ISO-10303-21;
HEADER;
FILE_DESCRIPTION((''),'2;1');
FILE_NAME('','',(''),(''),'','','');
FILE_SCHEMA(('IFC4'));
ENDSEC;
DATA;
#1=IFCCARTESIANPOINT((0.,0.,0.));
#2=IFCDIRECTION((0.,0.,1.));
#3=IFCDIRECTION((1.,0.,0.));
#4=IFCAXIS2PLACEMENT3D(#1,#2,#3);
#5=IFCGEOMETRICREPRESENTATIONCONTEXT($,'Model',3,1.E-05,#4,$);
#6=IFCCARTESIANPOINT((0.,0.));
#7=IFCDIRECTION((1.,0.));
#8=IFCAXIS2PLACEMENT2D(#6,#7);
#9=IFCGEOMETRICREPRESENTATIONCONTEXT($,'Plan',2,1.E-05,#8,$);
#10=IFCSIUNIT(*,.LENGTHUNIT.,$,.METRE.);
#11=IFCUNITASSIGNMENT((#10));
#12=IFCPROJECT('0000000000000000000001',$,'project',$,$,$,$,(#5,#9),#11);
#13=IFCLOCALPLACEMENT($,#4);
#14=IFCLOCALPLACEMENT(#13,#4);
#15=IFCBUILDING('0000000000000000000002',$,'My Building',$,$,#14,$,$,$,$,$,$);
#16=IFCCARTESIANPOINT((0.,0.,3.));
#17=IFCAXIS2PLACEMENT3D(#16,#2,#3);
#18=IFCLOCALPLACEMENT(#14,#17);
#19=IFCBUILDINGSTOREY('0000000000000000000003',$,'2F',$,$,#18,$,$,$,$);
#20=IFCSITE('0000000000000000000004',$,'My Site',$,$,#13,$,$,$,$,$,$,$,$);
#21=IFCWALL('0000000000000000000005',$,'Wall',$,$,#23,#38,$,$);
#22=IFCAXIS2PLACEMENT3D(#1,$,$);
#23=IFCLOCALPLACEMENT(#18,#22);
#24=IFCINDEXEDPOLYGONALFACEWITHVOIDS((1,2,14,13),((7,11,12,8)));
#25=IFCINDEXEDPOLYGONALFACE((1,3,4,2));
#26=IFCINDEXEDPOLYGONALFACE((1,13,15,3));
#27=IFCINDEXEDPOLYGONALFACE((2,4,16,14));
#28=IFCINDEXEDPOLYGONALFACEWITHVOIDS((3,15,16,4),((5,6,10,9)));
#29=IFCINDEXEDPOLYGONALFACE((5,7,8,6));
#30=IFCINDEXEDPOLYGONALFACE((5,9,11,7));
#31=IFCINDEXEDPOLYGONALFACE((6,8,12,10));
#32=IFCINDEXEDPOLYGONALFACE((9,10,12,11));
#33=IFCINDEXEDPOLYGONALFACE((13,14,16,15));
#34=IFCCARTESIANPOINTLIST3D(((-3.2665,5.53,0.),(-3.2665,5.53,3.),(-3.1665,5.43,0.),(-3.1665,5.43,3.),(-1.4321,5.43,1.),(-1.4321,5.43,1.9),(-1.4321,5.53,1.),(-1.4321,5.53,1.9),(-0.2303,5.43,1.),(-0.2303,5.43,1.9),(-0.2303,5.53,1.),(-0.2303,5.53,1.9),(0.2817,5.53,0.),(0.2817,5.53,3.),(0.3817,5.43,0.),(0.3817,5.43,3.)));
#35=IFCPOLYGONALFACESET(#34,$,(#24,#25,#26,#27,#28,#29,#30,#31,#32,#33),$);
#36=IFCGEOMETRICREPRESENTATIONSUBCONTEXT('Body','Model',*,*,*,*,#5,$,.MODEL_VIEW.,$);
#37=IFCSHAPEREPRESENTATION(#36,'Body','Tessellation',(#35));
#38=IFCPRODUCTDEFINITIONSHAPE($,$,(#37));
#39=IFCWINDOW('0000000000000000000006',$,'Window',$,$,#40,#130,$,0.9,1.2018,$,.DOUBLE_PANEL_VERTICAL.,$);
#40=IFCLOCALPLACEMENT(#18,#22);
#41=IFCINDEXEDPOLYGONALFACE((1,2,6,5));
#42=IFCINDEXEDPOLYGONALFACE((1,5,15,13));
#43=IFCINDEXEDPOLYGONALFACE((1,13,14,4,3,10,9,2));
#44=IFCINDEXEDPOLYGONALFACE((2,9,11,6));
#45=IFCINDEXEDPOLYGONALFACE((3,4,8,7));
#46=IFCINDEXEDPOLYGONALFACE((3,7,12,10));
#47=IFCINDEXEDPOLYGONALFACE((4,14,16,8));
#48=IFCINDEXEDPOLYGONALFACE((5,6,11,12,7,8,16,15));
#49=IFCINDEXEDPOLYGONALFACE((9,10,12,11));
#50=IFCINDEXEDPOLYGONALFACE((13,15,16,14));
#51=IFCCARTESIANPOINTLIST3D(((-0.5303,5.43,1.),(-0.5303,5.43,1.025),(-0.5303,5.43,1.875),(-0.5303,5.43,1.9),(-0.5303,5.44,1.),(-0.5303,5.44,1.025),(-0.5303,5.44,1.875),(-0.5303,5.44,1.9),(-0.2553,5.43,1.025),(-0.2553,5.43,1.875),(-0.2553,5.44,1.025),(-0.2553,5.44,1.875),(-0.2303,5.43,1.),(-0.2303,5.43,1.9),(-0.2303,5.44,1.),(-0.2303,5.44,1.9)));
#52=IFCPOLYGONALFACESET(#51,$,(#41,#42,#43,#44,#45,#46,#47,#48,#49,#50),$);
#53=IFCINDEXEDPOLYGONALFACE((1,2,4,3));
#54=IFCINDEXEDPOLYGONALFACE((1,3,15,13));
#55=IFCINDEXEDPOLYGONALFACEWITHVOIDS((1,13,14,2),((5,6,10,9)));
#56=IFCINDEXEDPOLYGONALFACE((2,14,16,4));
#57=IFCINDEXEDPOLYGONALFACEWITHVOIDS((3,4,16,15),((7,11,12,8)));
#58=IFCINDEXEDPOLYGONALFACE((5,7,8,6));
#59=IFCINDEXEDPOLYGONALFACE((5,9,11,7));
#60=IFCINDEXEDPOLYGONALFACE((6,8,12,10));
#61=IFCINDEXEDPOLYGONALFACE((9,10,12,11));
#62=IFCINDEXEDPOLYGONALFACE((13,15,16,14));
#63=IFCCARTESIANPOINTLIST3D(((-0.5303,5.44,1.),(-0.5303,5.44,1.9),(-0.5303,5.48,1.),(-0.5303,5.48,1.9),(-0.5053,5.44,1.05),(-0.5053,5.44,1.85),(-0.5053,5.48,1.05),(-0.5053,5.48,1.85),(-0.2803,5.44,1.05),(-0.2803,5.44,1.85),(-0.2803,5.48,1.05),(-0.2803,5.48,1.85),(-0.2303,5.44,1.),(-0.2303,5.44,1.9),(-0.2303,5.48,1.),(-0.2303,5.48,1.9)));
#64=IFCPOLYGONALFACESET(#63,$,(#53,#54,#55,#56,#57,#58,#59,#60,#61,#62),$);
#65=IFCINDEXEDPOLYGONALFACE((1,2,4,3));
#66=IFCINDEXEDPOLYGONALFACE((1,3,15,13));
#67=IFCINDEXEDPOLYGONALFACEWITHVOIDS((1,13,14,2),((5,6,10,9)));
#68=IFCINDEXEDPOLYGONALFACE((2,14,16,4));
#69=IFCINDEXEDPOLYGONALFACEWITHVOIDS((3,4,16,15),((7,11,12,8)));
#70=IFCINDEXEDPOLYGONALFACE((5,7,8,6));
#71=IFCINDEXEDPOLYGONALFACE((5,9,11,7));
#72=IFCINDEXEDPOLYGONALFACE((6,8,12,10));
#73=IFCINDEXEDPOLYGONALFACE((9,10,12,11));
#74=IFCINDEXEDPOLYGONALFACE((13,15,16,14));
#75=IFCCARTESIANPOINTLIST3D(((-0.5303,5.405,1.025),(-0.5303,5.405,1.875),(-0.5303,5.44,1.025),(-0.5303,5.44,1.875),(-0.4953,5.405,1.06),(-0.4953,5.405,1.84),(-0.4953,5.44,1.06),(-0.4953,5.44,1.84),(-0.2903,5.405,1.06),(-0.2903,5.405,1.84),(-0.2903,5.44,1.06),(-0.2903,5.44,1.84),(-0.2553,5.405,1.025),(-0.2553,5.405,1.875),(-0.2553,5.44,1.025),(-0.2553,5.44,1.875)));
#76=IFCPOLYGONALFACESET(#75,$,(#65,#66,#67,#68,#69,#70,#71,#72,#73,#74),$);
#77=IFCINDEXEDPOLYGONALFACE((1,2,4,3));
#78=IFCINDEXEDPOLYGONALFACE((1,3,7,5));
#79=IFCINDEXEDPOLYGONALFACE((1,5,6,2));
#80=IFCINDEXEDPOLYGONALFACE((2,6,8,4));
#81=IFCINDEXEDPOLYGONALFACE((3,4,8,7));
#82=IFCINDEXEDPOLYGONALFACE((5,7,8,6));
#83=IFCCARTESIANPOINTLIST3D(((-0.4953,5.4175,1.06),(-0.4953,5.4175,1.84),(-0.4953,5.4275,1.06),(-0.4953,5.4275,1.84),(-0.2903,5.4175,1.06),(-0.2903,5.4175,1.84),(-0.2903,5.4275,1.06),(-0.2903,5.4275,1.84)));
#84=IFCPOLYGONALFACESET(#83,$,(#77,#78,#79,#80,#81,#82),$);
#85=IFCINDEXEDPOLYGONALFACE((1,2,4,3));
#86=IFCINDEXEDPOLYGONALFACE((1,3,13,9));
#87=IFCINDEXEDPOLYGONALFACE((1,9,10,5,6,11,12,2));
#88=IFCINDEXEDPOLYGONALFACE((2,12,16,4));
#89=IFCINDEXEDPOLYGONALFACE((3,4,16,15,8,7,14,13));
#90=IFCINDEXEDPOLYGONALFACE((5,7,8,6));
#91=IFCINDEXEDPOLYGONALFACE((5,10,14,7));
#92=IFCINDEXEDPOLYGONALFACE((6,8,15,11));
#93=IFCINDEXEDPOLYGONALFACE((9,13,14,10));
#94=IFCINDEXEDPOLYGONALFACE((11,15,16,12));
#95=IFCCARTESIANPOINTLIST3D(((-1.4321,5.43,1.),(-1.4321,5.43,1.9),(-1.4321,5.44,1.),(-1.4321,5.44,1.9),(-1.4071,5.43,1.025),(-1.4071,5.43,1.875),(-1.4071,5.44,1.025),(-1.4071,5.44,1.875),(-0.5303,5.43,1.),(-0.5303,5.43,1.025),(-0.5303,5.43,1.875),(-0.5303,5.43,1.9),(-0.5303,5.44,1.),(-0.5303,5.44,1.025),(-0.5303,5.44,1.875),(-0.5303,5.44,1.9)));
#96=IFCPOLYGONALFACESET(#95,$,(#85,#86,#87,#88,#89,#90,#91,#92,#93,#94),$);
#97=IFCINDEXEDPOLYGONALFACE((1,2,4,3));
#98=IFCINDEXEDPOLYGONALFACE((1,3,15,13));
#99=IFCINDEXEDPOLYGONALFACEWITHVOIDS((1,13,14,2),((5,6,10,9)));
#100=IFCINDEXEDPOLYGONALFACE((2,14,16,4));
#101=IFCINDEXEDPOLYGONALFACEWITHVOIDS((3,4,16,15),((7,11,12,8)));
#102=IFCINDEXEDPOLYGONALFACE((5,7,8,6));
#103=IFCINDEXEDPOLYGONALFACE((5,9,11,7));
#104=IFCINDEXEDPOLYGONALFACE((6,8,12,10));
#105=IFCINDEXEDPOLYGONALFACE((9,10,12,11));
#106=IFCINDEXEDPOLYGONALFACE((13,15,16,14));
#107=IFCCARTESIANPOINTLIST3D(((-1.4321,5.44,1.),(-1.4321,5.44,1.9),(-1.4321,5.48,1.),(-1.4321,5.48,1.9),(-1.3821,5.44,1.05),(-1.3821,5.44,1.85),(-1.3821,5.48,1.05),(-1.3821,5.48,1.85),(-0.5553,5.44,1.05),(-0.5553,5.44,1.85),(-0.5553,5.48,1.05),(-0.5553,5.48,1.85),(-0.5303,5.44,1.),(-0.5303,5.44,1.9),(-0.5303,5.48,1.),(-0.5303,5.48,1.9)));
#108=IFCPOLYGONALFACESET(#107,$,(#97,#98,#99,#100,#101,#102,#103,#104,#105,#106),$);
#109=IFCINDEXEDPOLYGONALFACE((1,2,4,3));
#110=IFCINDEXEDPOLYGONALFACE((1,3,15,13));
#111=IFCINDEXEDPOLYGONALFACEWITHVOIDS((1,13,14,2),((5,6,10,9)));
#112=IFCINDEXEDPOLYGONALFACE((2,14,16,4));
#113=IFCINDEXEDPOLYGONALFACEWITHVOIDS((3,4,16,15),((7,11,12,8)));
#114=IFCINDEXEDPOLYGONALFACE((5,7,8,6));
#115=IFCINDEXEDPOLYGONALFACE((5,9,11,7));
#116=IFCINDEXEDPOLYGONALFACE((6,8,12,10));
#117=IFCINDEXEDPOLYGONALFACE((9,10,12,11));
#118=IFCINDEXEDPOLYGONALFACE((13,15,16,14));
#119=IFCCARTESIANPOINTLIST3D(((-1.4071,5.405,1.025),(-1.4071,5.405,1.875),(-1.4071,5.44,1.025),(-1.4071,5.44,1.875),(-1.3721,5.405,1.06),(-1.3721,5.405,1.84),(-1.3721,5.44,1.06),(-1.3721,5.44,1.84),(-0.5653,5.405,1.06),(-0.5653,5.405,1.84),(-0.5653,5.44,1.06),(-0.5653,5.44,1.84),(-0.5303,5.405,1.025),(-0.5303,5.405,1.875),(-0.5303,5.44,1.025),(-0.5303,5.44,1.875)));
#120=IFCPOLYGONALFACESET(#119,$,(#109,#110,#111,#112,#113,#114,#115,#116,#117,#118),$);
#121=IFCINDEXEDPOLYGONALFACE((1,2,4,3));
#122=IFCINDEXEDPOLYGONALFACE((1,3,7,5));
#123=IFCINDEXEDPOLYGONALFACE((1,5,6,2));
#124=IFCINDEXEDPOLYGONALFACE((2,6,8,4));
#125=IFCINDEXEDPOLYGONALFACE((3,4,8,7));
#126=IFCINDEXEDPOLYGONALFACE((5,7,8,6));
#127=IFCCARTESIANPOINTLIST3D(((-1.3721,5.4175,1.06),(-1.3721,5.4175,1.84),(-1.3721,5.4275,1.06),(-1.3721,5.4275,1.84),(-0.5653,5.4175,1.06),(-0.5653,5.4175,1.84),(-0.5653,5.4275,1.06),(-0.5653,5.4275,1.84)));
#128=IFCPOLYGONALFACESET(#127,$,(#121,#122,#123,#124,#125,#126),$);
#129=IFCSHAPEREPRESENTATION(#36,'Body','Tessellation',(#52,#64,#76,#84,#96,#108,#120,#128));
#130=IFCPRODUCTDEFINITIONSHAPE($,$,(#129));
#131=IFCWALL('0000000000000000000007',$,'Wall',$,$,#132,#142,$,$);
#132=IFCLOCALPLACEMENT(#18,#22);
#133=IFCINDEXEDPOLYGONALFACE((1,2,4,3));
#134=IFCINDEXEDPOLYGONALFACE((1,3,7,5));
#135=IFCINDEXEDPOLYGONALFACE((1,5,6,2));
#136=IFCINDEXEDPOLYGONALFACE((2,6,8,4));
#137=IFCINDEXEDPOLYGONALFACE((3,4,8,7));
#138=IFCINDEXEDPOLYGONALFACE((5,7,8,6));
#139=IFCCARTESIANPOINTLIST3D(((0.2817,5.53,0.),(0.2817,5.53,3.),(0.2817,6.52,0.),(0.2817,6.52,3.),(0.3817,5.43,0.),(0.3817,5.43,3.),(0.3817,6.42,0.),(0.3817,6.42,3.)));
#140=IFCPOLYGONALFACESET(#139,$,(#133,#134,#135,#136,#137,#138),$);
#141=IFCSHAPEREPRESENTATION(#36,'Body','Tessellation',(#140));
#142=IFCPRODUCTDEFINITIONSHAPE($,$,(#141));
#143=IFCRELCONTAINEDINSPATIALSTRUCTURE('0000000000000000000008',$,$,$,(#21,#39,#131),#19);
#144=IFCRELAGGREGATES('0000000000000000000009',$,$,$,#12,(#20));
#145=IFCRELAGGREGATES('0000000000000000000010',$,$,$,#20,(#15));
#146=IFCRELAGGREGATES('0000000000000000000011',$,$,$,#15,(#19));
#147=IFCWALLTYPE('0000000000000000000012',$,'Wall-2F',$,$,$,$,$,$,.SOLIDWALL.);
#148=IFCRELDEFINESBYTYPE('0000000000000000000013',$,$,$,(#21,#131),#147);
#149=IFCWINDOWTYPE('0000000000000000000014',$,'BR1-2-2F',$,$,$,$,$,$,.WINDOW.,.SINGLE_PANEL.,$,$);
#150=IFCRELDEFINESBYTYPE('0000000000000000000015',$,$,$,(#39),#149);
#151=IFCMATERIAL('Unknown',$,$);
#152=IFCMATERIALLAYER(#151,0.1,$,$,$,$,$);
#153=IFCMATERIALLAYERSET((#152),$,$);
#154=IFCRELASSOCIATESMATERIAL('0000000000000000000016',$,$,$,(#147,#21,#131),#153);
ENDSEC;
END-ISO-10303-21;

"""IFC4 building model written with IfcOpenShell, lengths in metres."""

from ifc_helpers import new_model, entity, si_unit, frame, origin_with_axes, origin_2d_with_axis, place, context, subcontext, project, spatial, line, indexed_curve, outline, extrude, shape, source, transform, mapped, material, layer, layer_set, layer_usage, type_object, type_shapes, element, fill, save


model = new_model("IFC4")

# Units and contexts
model_context = context("Model", 3, precision=1e-05, world=origin_with_axes())
plan_context = context("Plan", 2, precision=1e-05, world=origin_2d_with_axis())
body_context_1 = subcontext(model_context, "Body", "Model", "MODEL_VIEW")
body_context_2 = subcontext(plan_context, "Body", "Plan", "PLAN_VIEW")
ifc_project = project(units=[si_unit("LENGTHUNIT", "METRE")], contexts=[model_context, plan_context])

# Site, building, storey
site_placement = place(None, origin_with_axes())
site = spatial("IfcSite", under=ifc_project, at=site_placement, Name="My Site")
building_placement = place(site_placement, origin_with_axes())
building = spatial("IfcBuilding", under=site, at=building_placement, Name="My Building")
storey_placement = place(building_placement, frame((0.0, 0.0, 3.0), z_axis=(0.0, 0.0, 1.0), x_axis=(1.0, 0.0, 0.0)))
storey = spatial("IfcBuildingStorey", under=building, at=storey_placement, Name="2F")

# Shared definitions
ifc_material = material(Name="Unknown")

# Shared definitions
ifc_layer_1 = layer(ifc_material, 0.1)
ifc_layer_set_1 = layer_set([ifc_layer_1])
wall_type_1 = type_object("IfcWallType", Name="Wall-2F", PredefinedType="SOLIDWALL", material=ifc_layer_set_1)

# Wall, opening, window
ifc_layer_usage_1 = layer_usage(ifc_layer_set_1, "AXIS2", "POSITIVE", 0.0)
wall_1_placement = place(storey_placement, frame((0.2817, 5.53, 0.0), z_axis=(0.0, 0.0, 1.0), x_axis=(-1.0, 0.0, 0.0)))
wall_1 = element("IfcWall", 1, at=wall_1_placement, inside=storey, type_object=wall_type_1, material=ifc_layer_usage_1, Name="Wall", context=body_context_1, shape_type="SweptSolid", body=[
    extrude(outline(indexed_curve([(0.0, 0.0), (-0.1, 0.1), (3.4482, 0.1), (3.5482, 0.0)], segments=[line(1, 2, 3, 4, 1)])), origin_with_axes(), (0.0, 0.0, 1.0), 3.0),
])
shared_shape_1 = source(origin_with_axes(), body_context_1, "Body", "SweptSolid", [
    extrude(outline(indexed_curve([(0.0, 0.0), (1.2018, 0.0), (1.2018, 0.9), (0.0, 0.9)], segments=[line(1, 2, 3, 4, 1)])), frame((0.0, -0.6, 0.0), z_axis=(0.0, -1.0, 0.0), x_axis=(1.0, 0.0, 0.0)), (0.0, 0.0, -1.0), 1.2),
])
opening_1_placement = place(wall_1_placement, frame((0.512, 0.0, 1.0), z_axis=(0.0, 0.0, 1.0), x_axis=(1.0, 0.0, 0.0)))
opening_1 = element("IfcOpeningElement", 2, at=opening_1_placement, cuts=wall_1, PredefinedType="OPENING", context=body_context_1, shape_type="MappedRepresentation", body=[
    mapped(shared_shape_1, transform((0.0, 0.0, 0.0), x_axis=(1.0, 0.0, 0.0), y_axis=(0.0, 1.0, 0.0), z_axis=(0.0, 0.0, 1.0), scale=1.0)),
])
window_type_1 = type_object("IfcWindowType", Name="BR1-2-2F", PartitioningType="SINGLE_PANEL", PredefinedType="WINDOW")
shared_shape_2 = source(origin_with_axes(), body_context_1, "Body", "SweptSolid", [
    extrude(outline(indexed_curve([(0.3, 0.0), (0.0, 0.0), (0.0, 0.9), (0.3, 0.9), (0.3, 0.875), (0.025, 0.875), (0.025, 0.025), (0.3, 0.025)], segments=[line(1, 2, 3, 4, 5, 6, 7, 8, 1)])), frame((0.0, 0.09, 0.0), z_axis=(0.0, -1.0, 0.0), x_axis=(1.0, 0.0, 0.0)), (0.0, 0.0, -1.0), 0.01),
    extrude(outline(indexed_curve([(0.0, 0.0), (0.3, 0.0), (0.3, 0.9), (0.0, 0.9)], segments=[line(1, 2, 3, 4, 1)]), holes=[indexed_curve([(0.05, 0.05), (0.275, 0.05), (0.275, 0.85), (0.05, 0.85)], segments=[line(1, 2, 3, 4, 1)])]), frame((0.0, 0.05, 0.0), z_axis=(0.0, -1.0, 0.0), x_axis=(1.0, 0.0, 0.0)), (0.0, 0.0, -1.0), 0.04),
    extrude(outline(indexed_curve([(0.0, 0.0), (0.275, 0.0), (0.275, 0.85), (0.0, 0.85)], segments=[line(1, 2, 3, 4, 1)]), holes=[indexed_curve([(0.035, 0.035), (0.24, 0.035), (0.24, 0.815), (0.035, 0.815)], segments=[line(1, 2, 3, 4, 1)])]), frame((0.025, 0.09, 0.025), z_axis=(0.0, -1.0, 0.0), x_axis=(1.0, 0.0, 0.0)), (0.0, 0.0, -1.0), 0.035),
    extrude(outline(indexed_curve([(0.035, 0.035), (0.24, 0.035), (0.24, 0.815), (0.035, 0.815)], segments=[line(1, 2, 3, 4, 1)])), frame((0.025, 0.1025, 0.025), z_axis=(0.0, -1.0, 0.0), x_axis=(1.0, 0.0, 0.0)), (0.0, 0.0, -1.0), 0.01),
    extrude(outline(indexed_curve([(0.0, 0.9), (0.9018, 0.9), (0.9018, 0.0), (0.0, 0.0), (0.0, 0.025), (0.8768, 0.025), (0.8768, 0.875), (0.0, 0.875)], segments=[line(1, 2, 3, 4, 5, 6, 7, 8, 1)])), frame((0.3, 0.09, 0.0), z_axis=(0.0, -1.0, 0.0), x_axis=(1.0, 0.0, 0.0)), (0.0, 0.0, -1.0), 0.01),
    extrude(outline(indexed_curve([(0.0, 0.0), (0.9018, 0.0), (0.9018, 0.9), (0.0, 0.9)], segments=[line(1, 2, 3, 4, 1)]), holes=[indexed_curve([(0.025, 0.05), (0.8518, 0.05), (0.8518, 0.85), (0.025, 0.85)], segments=[line(1, 2, 3, 4, 1)])]), frame((0.3, 0.05, 0.0), z_axis=(0.0, -1.0, 0.0), x_axis=(1.0, 0.0, 0.0)), (0.0, 0.0, -1.0), 0.04),
    extrude(outline(indexed_curve([(0.0, 0.0), (0.8768, 0.0), (0.8768, 0.85), (0.0, 0.85)], segments=[line(1, 2, 3, 4, 1)]), holes=[indexed_curve([(0.035, 0.035), (0.8418, 0.035), (0.8418, 0.815), (0.035, 0.815)], segments=[line(1, 2, 3, 4, 1)])]), frame((0.3, 0.09, 0.025), z_axis=(0.0, -1.0, 0.0), x_axis=(1.0, 0.0, 0.0)), (0.0, 0.0, -1.0), 0.035),
    extrude(outline(indexed_curve([(0.035, 0.035), (0.8418, 0.035), (0.8418, 0.815), (0.035, 0.815)], segments=[line(1, 2, 3, 4, 1)])), frame((0.3, 0.1025, 0.025), z_axis=(0.0, -1.0, 0.0), x_axis=(1.0, 0.0, 0.0)), (0.0, 0.0, -1.0), 0.01),
])
shared_shape_3 = source(origin_with_axes(), body_context_2, "Body", "Curve2D", [
    entity("IfcIndexedPolyCurve", entity("IfcCartesianPointList2D", [[0.05, 0.05], [0.275, 0.05]])),
    entity("IfcIndexedPolyCurve", entity("IfcCartesianPointList2D", [[0.0, 0.1], [0.025, 0.1], [0.025, 0.09], [0.05, 0.09], [0.05, 0.05], [0.0, 0.05]]), [entity("IfcLineIndex", [1, 2, 3, 4, 5, 6, 1])]),
    entity("IfcIndexedPolyCurve", entity("IfcCartesianPointList2D", [[0.3, 0.1], [0.3, 0.1], [0.3, 0.09], [0.275, 0.09], [0.275, 0.05], [0.3, 0.05]])),
    entity("IfcIndexedPolyCurve", entity("IfcCartesianPointList2D", [[0.025, 0.09], [0.06, 0.09], [0.06, 0.125], [0.025, 0.125]]), [entity("IfcLineIndex", [1, 2, 3, 4, 1])]),
    entity("IfcIndexedPolyCurve", entity("IfcCartesianPointList2D", [[0.3, 0.09], [0.265, 0.09], [0.265, 0.125], [0.3, 0.125]]), [entity("IfcLineIndex", [1, 2, 3, 4, 1])]),
    entity("IfcIndexedPolyCurve", entity("IfcCartesianPointList2D", [[0.06, 0.09], [0.265, 0.09]])),
    entity("IfcIndexedPolyCurve", entity("IfcCartesianPointList2D", [[0.06, 0.125], [0.265, 0.125]])),
    entity("IfcIndexedPolyCurve", entity("IfcCartesianPointList2D", [[0.06, 0.1075], [0.265, 0.1075]])),
    entity("IfcIndexedPolyCurve", entity("IfcCartesianPointList2D", [[0.325, 0.05], [1.1518, 0.05]])),
    entity("IfcIndexedPolyCurve", entity("IfcCartesianPointList2D", [[0.3, 0.1], [0.3, 0.1], [0.3, 0.09], [0.325, 0.09], [0.325, 0.05], [0.3, 0.05]])),
    entity("IfcIndexedPolyCurve", entity("IfcCartesianPointList2D", [[1.2018, 0.1], [1.1768, 0.1], [1.1768, 0.09], [1.1518, 0.09], [1.1518, 0.05], [1.2018, 0.05]]), [entity("IfcLineIndex", [1, 2, 3, 4, 5, 6, 1])]),
    entity("IfcIndexedPolyCurve", entity("IfcCartesianPointList2D", [[0.3, 0.09], [0.335, 0.09], [0.335, 0.125], [0.3, 0.125]]), [entity("IfcLineIndex", [1, 2, 3, 4, 1])]),
    entity("IfcIndexedPolyCurve", entity("IfcCartesianPointList2D", [[1.1768, 0.09], [1.1418, 0.09], [1.1418, 0.125], [1.1768, 0.125]]), [entity("IfcLineIndex", [1, 2, 3, 4, 1])]),
    entity("IfcIndexedPolyCurve", entity("IfcCartesianPointList2D", [[0.335, 0.09], [1.1418, 0.09]])),
    entity("IfcIndexedPolyCurve", entity("IfcCartesianPointList2D", [[0.335, 0.125], [1.1418, 0.125]])),
    entity("IfcIndexedPolyCurve", entity("IfcCartesianPointList2D", [[0.335, 0.1075], [1.1418, 0.1075]])),
])
type_shapes(window_type_1, [shared_shape_2, shared_shape_3])
window_1_placement = place(opening_1_placement, origin_with_axes())
window_1 = element("IfcWindow", 3, at=window_1_placement, inside=storey, type_object=window_type_1, Name="Window", OverallHeight=0.9, OverallWidth=1.2018, PartitioningType="DOUBLE_PANEL_VERTICAL", shapes=[
    shape(body_context_1, "Body", "MappedRepresentation", [mapped(shared_shape_2, transform((0.0, 0.0, 0.0), x_axis=(1.0, 0.0, 0.0), y_axis=(0.0, 1.0, 0.0), z_axis=(0.0, 0.0, 1.0), scale=1.0))]),
    shape(body_context_2, "Body", "MappedRepresentation", [mapped(shared_shape_3, transform((0.0, 0.0, 0.0), x_axis=(1.0, 0.0, 0.0), y_axis=(0.0, 1.0, 0.0), z_axis=(0.0, 0.0, 1.0), scale=1.0))]),
])
fill(opening_1, window_1)

# Wall
ifc_layer_usage_2 = layer_usage(ifc_layer_set_1, "AXIS2", "POSITIVE", 0.0)
wall_2_placement = place(storey_placement, frame((0.2817, 6.52, 0.0), z_axis=(0.0, 0.0, 1.0), x_axis=(0.0, -1.0, 0.0)))
element("IfcWall", 4, at=wall_2_placement, inside=storey, type_object=wall_type_1, material=ifc_layer_usage_2, Name="Wall", context=body_context_1, shape_type="SweptSolid", body=[
    extrude(outline(indexed_curve([(0.0, 0.0), (0.1, 0.1), (1.09, 0.1), (0.99, 0.0)], segments=[line(1, 2, 3, 4, 1)])), origin_with_axes(), (0.0, 0.0, 1.0), 3.0),
])

save(model, "model.ifc")
